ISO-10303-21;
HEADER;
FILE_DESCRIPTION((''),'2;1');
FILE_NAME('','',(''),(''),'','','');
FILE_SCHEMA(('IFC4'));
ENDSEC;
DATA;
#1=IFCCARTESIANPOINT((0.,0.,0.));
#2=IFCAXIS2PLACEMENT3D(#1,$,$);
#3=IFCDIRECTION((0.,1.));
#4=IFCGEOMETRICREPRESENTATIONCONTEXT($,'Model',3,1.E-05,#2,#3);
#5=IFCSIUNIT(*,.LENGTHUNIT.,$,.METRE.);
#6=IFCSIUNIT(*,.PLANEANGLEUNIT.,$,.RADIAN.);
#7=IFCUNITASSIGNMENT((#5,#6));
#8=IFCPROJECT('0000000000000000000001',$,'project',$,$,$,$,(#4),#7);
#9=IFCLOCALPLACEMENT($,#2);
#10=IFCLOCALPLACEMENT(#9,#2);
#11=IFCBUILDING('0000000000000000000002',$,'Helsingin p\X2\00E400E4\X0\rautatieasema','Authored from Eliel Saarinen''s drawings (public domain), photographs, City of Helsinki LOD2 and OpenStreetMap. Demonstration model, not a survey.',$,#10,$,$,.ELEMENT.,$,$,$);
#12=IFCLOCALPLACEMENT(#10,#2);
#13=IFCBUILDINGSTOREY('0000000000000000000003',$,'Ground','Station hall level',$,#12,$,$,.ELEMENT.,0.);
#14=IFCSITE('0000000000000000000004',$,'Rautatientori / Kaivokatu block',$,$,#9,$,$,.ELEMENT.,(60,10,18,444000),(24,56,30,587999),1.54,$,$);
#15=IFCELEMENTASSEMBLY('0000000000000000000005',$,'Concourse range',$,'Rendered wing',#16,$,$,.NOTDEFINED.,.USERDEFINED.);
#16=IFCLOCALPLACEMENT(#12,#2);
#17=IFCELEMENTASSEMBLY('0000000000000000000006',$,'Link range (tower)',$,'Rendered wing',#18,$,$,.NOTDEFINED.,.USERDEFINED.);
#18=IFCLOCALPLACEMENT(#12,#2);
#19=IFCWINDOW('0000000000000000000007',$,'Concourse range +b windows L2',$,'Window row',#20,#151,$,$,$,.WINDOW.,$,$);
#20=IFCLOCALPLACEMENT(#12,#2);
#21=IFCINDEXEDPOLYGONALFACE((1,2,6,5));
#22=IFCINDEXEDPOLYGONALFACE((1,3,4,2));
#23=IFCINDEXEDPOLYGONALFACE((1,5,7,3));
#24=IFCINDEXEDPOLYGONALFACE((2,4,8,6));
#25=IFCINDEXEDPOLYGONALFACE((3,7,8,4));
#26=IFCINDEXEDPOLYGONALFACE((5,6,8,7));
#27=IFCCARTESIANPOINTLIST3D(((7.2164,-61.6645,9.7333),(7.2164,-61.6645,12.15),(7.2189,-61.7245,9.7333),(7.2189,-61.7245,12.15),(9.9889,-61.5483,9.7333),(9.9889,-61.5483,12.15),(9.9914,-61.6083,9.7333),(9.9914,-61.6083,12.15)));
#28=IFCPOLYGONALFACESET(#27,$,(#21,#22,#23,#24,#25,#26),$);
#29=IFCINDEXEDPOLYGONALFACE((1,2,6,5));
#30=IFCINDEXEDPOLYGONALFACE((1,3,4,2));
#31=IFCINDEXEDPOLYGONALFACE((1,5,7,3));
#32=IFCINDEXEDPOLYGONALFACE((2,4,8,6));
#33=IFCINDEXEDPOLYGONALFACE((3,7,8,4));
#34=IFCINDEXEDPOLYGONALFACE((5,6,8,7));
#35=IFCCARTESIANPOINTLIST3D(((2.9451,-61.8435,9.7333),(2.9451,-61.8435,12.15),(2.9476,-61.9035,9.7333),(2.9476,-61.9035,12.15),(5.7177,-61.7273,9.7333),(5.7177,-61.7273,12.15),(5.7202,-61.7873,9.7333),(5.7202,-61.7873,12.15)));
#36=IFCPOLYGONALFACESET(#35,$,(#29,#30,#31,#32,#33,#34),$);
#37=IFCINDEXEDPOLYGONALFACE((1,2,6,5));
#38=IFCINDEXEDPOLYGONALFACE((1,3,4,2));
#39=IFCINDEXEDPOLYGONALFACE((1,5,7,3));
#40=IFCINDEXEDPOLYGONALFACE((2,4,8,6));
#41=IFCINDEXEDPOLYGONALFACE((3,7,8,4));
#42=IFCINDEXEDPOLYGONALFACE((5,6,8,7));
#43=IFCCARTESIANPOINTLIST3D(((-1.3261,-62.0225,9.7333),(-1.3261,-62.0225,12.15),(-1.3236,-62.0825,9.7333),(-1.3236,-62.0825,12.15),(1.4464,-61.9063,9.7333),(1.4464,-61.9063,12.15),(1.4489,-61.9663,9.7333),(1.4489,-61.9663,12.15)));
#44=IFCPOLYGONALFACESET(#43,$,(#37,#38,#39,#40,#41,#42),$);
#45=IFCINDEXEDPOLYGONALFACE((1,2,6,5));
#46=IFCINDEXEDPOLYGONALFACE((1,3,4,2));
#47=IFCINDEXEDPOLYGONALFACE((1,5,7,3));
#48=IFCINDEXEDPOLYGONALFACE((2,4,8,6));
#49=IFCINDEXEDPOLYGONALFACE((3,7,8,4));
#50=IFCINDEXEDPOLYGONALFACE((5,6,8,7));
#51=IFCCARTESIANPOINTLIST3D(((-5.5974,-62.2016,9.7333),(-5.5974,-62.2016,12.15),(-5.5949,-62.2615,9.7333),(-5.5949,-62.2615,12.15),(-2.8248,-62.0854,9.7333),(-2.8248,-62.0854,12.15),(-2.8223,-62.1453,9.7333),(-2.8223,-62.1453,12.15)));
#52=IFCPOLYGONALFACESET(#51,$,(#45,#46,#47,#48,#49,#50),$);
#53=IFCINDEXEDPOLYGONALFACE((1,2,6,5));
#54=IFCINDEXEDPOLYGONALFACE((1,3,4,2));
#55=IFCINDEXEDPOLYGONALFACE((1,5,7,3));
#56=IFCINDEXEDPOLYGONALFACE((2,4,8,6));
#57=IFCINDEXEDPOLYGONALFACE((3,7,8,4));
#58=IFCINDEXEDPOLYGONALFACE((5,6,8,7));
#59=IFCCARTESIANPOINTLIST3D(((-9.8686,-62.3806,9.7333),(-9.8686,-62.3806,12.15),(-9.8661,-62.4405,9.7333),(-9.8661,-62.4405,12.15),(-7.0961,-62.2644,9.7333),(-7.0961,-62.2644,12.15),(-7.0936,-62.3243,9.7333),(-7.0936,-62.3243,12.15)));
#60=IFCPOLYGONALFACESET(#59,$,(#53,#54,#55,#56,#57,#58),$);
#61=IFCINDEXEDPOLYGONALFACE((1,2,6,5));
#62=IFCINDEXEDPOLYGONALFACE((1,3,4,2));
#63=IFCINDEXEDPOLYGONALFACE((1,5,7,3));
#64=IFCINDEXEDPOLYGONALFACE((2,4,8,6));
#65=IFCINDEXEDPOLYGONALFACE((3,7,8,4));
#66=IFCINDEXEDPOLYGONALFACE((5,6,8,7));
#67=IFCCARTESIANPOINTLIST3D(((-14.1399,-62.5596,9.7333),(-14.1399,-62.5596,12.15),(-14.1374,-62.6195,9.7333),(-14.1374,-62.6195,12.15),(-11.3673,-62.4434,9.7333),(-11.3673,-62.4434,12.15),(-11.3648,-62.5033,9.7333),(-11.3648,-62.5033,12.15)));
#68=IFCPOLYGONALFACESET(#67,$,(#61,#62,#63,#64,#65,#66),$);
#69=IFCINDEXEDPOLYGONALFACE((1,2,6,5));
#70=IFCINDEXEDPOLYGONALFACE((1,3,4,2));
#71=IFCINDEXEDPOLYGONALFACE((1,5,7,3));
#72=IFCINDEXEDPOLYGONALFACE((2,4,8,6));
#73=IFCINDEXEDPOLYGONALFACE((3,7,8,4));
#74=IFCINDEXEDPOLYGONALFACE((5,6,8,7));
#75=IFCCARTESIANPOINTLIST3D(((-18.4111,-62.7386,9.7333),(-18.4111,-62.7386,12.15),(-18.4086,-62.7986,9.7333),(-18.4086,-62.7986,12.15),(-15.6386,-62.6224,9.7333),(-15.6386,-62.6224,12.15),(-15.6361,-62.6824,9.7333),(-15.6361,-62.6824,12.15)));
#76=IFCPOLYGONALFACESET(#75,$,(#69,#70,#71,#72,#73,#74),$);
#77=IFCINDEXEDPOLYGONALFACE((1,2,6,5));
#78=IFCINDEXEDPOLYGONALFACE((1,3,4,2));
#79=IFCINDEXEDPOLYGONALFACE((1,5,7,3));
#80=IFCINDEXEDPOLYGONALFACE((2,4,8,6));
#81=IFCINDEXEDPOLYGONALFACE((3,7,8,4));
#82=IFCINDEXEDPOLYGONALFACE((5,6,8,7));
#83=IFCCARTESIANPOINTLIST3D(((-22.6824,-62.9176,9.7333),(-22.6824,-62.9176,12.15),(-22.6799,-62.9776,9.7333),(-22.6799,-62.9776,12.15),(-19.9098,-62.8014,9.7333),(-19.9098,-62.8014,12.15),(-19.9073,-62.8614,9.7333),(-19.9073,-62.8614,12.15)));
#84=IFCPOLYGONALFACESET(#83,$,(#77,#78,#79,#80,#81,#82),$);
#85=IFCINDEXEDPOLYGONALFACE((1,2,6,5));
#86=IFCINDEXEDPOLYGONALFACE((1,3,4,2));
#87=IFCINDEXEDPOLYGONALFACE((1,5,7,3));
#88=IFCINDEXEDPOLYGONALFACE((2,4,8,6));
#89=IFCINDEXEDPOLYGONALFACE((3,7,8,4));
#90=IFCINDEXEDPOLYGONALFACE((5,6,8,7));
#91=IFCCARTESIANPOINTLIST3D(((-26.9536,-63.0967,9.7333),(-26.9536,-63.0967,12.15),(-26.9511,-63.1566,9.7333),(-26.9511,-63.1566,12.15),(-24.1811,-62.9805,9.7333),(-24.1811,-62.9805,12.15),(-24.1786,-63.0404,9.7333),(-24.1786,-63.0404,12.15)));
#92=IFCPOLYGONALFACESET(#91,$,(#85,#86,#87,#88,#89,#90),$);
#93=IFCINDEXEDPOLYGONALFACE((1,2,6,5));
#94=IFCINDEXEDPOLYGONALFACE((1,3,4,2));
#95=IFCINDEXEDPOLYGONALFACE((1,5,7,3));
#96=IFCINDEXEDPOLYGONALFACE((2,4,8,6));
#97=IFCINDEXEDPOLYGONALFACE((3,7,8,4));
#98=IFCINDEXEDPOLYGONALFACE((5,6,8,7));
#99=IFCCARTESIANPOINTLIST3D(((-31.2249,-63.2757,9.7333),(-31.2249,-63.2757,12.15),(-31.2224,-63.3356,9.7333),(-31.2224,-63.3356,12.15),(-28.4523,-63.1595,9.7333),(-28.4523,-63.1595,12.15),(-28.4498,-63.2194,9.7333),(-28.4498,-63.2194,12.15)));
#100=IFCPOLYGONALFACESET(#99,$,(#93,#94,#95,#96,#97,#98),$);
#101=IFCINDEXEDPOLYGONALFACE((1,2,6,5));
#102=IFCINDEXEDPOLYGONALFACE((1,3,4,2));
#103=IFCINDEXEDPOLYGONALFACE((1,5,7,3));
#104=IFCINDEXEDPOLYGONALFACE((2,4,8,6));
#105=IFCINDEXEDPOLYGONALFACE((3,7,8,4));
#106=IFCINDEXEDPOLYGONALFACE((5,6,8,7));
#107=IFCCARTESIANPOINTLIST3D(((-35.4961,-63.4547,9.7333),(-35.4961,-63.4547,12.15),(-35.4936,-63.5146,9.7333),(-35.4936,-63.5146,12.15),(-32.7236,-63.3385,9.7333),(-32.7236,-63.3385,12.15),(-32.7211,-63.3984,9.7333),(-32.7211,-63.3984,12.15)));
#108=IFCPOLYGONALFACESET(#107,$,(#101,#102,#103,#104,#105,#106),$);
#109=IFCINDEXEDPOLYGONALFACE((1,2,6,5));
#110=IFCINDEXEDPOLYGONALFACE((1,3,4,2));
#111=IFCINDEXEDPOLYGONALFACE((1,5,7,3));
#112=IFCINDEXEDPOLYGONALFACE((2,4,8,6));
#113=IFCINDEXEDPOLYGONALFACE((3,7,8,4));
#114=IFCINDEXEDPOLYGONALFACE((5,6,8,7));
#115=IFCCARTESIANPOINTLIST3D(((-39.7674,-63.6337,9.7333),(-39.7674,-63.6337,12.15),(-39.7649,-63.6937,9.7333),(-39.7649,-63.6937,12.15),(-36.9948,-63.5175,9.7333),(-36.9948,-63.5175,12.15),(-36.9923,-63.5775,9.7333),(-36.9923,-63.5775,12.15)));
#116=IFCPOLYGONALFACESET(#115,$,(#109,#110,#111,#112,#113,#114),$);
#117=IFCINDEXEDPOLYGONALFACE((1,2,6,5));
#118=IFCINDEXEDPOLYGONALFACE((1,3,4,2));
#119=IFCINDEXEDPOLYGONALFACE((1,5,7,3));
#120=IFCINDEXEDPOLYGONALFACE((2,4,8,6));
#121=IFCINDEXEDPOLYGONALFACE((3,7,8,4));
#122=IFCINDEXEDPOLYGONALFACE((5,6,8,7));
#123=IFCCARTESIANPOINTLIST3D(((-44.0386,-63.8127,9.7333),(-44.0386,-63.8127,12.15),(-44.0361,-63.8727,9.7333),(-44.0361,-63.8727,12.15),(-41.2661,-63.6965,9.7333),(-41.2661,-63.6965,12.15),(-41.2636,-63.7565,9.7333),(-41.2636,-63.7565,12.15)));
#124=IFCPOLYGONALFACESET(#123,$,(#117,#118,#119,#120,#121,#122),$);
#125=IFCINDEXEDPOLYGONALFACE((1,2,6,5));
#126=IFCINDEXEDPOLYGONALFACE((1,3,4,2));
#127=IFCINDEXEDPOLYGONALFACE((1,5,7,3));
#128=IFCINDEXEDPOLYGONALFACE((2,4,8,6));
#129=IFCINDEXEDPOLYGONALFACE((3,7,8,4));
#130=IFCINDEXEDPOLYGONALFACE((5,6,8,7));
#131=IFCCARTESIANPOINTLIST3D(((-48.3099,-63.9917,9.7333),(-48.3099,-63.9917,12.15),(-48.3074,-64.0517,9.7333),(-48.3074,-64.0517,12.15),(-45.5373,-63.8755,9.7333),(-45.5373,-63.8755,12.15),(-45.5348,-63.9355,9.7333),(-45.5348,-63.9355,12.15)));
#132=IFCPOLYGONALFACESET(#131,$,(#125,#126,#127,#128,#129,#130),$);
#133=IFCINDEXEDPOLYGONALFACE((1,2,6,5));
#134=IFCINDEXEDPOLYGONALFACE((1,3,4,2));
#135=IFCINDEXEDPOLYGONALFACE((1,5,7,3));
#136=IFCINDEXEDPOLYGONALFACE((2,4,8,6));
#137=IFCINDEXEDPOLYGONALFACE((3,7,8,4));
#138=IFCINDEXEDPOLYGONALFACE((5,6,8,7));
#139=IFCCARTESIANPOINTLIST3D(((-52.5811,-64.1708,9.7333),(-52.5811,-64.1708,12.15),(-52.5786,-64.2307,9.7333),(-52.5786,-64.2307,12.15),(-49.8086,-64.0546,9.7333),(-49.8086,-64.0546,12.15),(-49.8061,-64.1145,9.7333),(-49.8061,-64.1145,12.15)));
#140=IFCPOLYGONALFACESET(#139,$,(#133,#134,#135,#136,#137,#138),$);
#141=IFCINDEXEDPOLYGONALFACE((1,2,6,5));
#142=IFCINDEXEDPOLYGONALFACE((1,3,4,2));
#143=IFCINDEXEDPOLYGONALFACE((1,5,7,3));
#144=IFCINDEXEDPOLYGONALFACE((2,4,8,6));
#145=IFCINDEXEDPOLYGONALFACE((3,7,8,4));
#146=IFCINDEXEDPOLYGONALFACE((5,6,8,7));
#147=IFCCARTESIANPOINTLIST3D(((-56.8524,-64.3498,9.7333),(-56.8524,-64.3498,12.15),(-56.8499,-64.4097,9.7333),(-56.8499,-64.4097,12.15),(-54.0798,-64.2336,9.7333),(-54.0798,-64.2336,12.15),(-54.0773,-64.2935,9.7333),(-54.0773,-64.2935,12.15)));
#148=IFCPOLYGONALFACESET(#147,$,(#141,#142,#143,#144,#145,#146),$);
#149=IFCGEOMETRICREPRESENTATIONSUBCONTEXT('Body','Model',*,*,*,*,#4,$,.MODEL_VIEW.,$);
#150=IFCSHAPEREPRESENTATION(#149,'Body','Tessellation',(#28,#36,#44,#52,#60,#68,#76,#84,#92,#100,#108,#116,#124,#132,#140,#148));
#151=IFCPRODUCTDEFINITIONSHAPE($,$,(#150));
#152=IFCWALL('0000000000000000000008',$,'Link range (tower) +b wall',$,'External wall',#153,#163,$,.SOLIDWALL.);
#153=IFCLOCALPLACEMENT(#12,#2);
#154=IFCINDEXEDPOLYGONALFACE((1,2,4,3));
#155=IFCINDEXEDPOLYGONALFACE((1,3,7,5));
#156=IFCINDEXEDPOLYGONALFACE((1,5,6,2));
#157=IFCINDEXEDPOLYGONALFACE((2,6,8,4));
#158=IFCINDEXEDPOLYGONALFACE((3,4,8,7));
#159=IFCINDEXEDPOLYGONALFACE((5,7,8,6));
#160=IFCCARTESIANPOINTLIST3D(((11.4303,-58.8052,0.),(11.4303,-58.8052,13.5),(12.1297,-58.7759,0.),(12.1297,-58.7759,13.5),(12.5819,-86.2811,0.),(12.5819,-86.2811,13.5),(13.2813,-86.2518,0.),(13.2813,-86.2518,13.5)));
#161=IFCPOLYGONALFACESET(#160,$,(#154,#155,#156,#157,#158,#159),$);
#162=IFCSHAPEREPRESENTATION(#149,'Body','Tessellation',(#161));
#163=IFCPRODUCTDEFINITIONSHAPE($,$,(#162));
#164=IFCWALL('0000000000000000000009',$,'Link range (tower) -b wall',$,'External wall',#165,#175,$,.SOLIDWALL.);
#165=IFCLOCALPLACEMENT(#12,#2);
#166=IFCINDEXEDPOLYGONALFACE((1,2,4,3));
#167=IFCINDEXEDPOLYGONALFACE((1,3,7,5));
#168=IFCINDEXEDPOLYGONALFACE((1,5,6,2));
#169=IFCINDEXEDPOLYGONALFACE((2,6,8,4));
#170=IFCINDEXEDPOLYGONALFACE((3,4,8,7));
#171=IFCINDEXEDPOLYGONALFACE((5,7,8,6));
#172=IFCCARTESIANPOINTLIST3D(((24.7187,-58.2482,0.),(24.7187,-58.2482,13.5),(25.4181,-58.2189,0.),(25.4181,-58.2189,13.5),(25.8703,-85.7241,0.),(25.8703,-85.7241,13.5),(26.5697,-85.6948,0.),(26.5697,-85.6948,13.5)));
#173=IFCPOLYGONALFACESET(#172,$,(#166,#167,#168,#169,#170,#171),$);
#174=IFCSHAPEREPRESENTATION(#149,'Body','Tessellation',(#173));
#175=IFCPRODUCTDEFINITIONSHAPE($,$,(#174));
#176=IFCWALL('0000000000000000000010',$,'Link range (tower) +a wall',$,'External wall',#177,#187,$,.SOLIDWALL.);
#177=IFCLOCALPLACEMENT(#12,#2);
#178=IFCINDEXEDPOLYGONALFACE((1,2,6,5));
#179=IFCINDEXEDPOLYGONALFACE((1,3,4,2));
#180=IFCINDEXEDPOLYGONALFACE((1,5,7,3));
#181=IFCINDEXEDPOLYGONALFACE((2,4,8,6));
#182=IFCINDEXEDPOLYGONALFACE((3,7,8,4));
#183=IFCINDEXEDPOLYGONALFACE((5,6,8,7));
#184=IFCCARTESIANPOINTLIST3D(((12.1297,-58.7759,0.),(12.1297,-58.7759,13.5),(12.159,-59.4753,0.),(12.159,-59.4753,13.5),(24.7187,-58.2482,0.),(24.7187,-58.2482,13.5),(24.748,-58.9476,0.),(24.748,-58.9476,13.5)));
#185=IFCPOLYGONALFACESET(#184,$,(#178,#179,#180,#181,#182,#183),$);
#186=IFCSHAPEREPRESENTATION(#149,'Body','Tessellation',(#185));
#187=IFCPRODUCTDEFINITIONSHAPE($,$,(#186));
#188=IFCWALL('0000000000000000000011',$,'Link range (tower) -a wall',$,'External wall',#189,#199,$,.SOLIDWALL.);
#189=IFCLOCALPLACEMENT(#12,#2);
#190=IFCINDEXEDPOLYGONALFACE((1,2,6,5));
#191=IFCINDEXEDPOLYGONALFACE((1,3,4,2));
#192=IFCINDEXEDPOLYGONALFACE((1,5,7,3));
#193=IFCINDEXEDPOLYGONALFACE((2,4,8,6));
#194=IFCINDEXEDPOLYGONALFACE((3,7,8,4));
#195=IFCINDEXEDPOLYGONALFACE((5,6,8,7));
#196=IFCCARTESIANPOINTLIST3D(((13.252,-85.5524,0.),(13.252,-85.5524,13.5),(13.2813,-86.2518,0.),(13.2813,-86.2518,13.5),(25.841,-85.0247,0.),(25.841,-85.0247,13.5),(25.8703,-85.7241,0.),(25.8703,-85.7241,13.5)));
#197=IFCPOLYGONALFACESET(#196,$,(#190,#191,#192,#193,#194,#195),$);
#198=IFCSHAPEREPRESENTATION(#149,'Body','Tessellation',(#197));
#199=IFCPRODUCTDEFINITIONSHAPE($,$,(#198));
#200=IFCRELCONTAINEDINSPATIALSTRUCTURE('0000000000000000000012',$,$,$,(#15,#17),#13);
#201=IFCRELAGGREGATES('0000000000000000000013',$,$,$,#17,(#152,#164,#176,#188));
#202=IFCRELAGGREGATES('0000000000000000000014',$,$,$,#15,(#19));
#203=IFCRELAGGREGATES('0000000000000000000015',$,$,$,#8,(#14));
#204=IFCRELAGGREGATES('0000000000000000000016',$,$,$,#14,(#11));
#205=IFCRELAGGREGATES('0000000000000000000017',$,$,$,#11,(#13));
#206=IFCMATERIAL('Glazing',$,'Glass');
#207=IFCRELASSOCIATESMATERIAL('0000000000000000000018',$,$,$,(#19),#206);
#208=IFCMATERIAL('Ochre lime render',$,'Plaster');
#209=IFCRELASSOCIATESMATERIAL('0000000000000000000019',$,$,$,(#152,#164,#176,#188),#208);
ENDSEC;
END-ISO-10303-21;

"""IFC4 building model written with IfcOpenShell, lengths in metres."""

from ifc_helpers import new_model, si_unit, direction, frame, frame_2d, origin, place, context, subcontext, project, spatial, rectangle, extrude, material, element, aggregate, save


model = new_model("IFC4")

# Units and contexts
model_context = context("Model", 3, precision=1e-05, world=origin(), true_north=direction((0.0, 1.0)))
body_context = subcontext(model_context, "Body", "Model", "MODEL_VIEW")
ifc_project = project(units=[si_unit("LENGTHUNIT", "METRE"), si_unit("PLANEANGLEUNIT", "RADIAN")], contexts=[model_context])

# Site, building, storey
site_placement = place(None, origin())
site = spatial("IfcSite", under=ifc_project, at=site_placement, Name="Rautatientori / Kaivokatu block", CompositionType="ELEMENT", RefLatitude=(60, 10, 18, 444000), RefLongitude=(24, 56, 30, 587999), RefElevation=1.54)
building_placement = place(site_placement, origin())
building = spatial("IfcBuilding", under=site, at=building_placement, Name="Helsingin päärautatieasema", Description="Authored from Eliel Saarinen's drawings (public domain), photographs, City of Helsinki LOD2 and OpenStreetMap. Demonstration model, not a survey.", CompositionType="ELEMENT")
storey_placement = place(building_placement, origin())
storey = spatial("IfcBuildingStorey", under=building, at=storey_placement, Name="Ground", Description="Station hall level", CompositionType="ELEMENT", Elevation=0.0)

# Element assembly
assembly_1_placement = place(building_placement, origin())
assembly_1 = element("IfcElementAssembly", 1, at=assembly_1_placement, inside=storey, Name="Concourse range", ObjectType="Rendered wing", AssemblyPlace="NOTDEFINED", PredefinedType="USERDEFINED")
ifc_material_1 = material(Name="Ochre lime render", Category="Plaster")

# Element assembly
assembly_2_placement = place(building_placement, origin())
assembly_2 = element("IfcElementAssembly", 2, at=assembly_2_placement, inside=storey, Name="Link range (tower)", ObjectType="Rendered wing", AssemblyPlace="NOTDEFINED", PredefinedType="USERDEFINED")

# Window
ifc_material_2 = material(Name="Glazing", Category="Glass")
window_1_placement = place(building_placement, origin())
window_1 = element("IfcWindow", 3, at=window_1_placement, material=ifc_material_2, Name="Concourse range +b windows L2", ObjectType="Window row", PredefinedType="WINDOW", context=body_context, shape_type="SweptSolid", body=[
    extrude(rectangle(XDim=2.775, YDim=0.06, at=frame_2d((0.0, 0.0), x_axis=(-0.999123, -0.041876))), frame((8.6039, -61.6364, 9.7333)), (0.0, 0.0, 1.0), 2.4167),
    extrude(rectangle(XDim=2.775, YDim=0.06, at=frame_2d((0.0, 0.0), x_axis=(-0.999123, -0.041876))), frame((4.3326, -61.8154, 9.7333)), (0.0, 0.0, 1.0), 2.4167),
    extrude(rectangle(XDim=2.775, YDim=0.06, at=frame_2d((0.0, 0.0), x_axis=(-0.999123, -0.041876))), frame((0.0614, -61.9944, 9.7333)), (0.0, 0.0, 1.0), 2.4167),
    extrude(rectangle(XDim=2.775, YDim=0.06, at=frame_2d((0.0, 0.0), x_axis=(-0.999123, -0.041876))), frame((-4.2099, -62.1734, 9.7333)), (0.0, 0.0, 1.0), 2.4167),
    extrude(rectangle(XDim=2.775, YDim=0.06, at=frame_2d((0.0, 0.0), x_axis=(-0.999123, -0.041876))), frame((-8.4811, -62.3525, 9.7333)), (0.0, 0.0, 1.0), 2.4167),
    extrude(rectangle(XDim=2.775, YDim=0.06, at=frame_2d((0.0, 0.0), x_axis=(-0.999123, -0.041876))), frame((-12.7524, -62.5315, 9.7333)), (0.0, 0.0, 1.0), 2.4167),
    extrude(rectangle(XDim=2.775, YDim=0.06, at=frame_2d((0.0, 0.0), x_axis=(-0.999123, -0.041876))), frame((-17.0236, -62.7105, 9.7333)), (0.0, 0.0, 1.0), 2.4167),
    extrude(rectangle(XDim=2.775, YDim=0.06, at=frame_2d((0.0, 0.0), x_axis=(-0.999123, -0.041876))), frame((-21.2949, -62.8895, 9.7333)), (0.0, 0.0, 1.0), 2.4167),
    extrude(rectangle(XDim=2.775, YDim=0.06, at=frame_2d((0.0, 0.0), x_axis=(-0.999123, -0.041876))), frame((-25.5661, -63.0685, 9.7333)), (0.0, 0.0, 1.0), 2.4167),
    extrude(rectangle(XDim=2.775, YDim=0.06, at=frame_2d((0.0, 0.0), x_axis=(-0.999123, -0.041876))), frame((-29.8374, -63.2475, 9.7333)), (0.0, 0.0, 1.0), 2.4167),
    extrude(rectangle(XDim=2.775, YDim=0.06, at=frame_2d((0.0, 0.0), x_axis=(-0.999123, -0.041876))), frame((-34.1086, -63.4266, 9.7333)), (0.0, 0.0, 1.0), 2.4167),
    extrude(rectangle(XDim=2.775, YDim=0.06, at=frame_2d((0.0, 0.0), x_axis=(-0.999123, -0.041876))), frame((-38.3799, -63.6056, 9.7333)), (0.0, 0.0, 1.0), 2.4167),
    extrude(rectangle(XDim=2.775, YDim=0.06, at=frame_2d((0.0, 0.0), x_axis=(-0.999123, -0.041876))), frame((-42.6511, -63.7846, 9.7333)), (0.0, 0.0, 1.0), 2.4167),
    extrude(rectangle(XDim=2.775, YDim=0.06, at=frame_2d((0.0, 0.0), x_axis=(-0.999123, -0.041876))), frame((-46.9224, -63.9636, 9.7333)), (0.0, 0.0, 1.0), 2.4167),
    extrude(rectangle(XDim=2.775, YDim=0.06, at=frame_2d((0.0, 0.0), x_axis=(-0.999123, -0.041876))), frame((-51.1936, -64.1426, 9.7333)), (0.0, 0.0, 1.0), 2.4167),
    extrude(rectangle(XDim=2.775, YDim=0.06, at=frame_2d((0.0, 0.0), x_axis=(-0.999123, -0.041876))), frame((-55.4649, -64.3217, 9.7333)), (0.0, 0.0, 1.0), 2.4167),
])

# Walls
wall_1_placement = place(building_placement, origin())
wall_1 = element("IfcWall", 4, at=wall_1_placement, material=ifc_material_1, Name="Link range (tower) +b wall", ObjectType="External wall", PredefinedType="SOLIDWALL", context=body_context, shape_type="SweptSolid", body=[
    extrude(rectangle(XDim=27.5, YDim=0.7, at=frame_2d((0.0, 0.0), x_axis=(0.041876, -0.999123))), frame((12.3558, -72.5285, 0.0)), (0.0, 0.0, 1.0), 13.5),
])
wall_2_placement = place(building_placement, origin())
wall_2 = element("IfcWall", 5, at=wall_2_placement, material=ifc_material_1, Name="Link range (tower) -b wall", ObjectType="External wall", PredefinedType="SOLIDWALL", context=body_context, shape_type="SweptSolid", body=[
    extrude(rectangle(XDim=27.5, YDim=0.7, at=frame_2d((0.0, 0.0), x_axis=(-0.041876, 0.999123))), frame((25.6442, -71.9715, 0.0)), (0.0, 0.0, 1.0), 13.5),
])
wall_3_placement = place(building_placement, origin())
wall_3 = element("IfcWall", 6, at=wall_3_placement, material=ifc_material_1, Name="Link range (tower) +a wall", ObjectType="External wall", PredefinedType="SOLIDWALL", context=body_context, shape_type="SweptSolid", body=[
    extrude(rectangle(XDim=12.6, YDim=0.7, at=frame_2d((0.0, 0.0), x_axis=(-0.999123, -0.041876))), frame((18.4389, -58.8618, 0.0)), (0.0, 0.0, 1.0), 13.5),
])
wall_4_placement = place(building_placement, origin())
wall_4 = element("IfcWall", 7, at=wall_4_placement, material=ifc_material_1, Name="Link range (tower) -a wall", ObjectType="External wall", PredefinedType="SOLIDWALL", context=body_context, shape_type="SweptSolid", body=[
    extrude(rectangle(XDim=12.6, YDim=0.7, at=frame_2d((0.0, 0.0), x_axis=(0.999123, 0.041876))), frame((19.5611, -85.6382, 0.0)), (0.0, 0.0, 1.0), 13.5),
])

aggregate(assembly_2, [wall_1, wall_2, wall_3, wall_4])

aggregate(assembly_1, [window_1])

save(model, "model.ifc")
